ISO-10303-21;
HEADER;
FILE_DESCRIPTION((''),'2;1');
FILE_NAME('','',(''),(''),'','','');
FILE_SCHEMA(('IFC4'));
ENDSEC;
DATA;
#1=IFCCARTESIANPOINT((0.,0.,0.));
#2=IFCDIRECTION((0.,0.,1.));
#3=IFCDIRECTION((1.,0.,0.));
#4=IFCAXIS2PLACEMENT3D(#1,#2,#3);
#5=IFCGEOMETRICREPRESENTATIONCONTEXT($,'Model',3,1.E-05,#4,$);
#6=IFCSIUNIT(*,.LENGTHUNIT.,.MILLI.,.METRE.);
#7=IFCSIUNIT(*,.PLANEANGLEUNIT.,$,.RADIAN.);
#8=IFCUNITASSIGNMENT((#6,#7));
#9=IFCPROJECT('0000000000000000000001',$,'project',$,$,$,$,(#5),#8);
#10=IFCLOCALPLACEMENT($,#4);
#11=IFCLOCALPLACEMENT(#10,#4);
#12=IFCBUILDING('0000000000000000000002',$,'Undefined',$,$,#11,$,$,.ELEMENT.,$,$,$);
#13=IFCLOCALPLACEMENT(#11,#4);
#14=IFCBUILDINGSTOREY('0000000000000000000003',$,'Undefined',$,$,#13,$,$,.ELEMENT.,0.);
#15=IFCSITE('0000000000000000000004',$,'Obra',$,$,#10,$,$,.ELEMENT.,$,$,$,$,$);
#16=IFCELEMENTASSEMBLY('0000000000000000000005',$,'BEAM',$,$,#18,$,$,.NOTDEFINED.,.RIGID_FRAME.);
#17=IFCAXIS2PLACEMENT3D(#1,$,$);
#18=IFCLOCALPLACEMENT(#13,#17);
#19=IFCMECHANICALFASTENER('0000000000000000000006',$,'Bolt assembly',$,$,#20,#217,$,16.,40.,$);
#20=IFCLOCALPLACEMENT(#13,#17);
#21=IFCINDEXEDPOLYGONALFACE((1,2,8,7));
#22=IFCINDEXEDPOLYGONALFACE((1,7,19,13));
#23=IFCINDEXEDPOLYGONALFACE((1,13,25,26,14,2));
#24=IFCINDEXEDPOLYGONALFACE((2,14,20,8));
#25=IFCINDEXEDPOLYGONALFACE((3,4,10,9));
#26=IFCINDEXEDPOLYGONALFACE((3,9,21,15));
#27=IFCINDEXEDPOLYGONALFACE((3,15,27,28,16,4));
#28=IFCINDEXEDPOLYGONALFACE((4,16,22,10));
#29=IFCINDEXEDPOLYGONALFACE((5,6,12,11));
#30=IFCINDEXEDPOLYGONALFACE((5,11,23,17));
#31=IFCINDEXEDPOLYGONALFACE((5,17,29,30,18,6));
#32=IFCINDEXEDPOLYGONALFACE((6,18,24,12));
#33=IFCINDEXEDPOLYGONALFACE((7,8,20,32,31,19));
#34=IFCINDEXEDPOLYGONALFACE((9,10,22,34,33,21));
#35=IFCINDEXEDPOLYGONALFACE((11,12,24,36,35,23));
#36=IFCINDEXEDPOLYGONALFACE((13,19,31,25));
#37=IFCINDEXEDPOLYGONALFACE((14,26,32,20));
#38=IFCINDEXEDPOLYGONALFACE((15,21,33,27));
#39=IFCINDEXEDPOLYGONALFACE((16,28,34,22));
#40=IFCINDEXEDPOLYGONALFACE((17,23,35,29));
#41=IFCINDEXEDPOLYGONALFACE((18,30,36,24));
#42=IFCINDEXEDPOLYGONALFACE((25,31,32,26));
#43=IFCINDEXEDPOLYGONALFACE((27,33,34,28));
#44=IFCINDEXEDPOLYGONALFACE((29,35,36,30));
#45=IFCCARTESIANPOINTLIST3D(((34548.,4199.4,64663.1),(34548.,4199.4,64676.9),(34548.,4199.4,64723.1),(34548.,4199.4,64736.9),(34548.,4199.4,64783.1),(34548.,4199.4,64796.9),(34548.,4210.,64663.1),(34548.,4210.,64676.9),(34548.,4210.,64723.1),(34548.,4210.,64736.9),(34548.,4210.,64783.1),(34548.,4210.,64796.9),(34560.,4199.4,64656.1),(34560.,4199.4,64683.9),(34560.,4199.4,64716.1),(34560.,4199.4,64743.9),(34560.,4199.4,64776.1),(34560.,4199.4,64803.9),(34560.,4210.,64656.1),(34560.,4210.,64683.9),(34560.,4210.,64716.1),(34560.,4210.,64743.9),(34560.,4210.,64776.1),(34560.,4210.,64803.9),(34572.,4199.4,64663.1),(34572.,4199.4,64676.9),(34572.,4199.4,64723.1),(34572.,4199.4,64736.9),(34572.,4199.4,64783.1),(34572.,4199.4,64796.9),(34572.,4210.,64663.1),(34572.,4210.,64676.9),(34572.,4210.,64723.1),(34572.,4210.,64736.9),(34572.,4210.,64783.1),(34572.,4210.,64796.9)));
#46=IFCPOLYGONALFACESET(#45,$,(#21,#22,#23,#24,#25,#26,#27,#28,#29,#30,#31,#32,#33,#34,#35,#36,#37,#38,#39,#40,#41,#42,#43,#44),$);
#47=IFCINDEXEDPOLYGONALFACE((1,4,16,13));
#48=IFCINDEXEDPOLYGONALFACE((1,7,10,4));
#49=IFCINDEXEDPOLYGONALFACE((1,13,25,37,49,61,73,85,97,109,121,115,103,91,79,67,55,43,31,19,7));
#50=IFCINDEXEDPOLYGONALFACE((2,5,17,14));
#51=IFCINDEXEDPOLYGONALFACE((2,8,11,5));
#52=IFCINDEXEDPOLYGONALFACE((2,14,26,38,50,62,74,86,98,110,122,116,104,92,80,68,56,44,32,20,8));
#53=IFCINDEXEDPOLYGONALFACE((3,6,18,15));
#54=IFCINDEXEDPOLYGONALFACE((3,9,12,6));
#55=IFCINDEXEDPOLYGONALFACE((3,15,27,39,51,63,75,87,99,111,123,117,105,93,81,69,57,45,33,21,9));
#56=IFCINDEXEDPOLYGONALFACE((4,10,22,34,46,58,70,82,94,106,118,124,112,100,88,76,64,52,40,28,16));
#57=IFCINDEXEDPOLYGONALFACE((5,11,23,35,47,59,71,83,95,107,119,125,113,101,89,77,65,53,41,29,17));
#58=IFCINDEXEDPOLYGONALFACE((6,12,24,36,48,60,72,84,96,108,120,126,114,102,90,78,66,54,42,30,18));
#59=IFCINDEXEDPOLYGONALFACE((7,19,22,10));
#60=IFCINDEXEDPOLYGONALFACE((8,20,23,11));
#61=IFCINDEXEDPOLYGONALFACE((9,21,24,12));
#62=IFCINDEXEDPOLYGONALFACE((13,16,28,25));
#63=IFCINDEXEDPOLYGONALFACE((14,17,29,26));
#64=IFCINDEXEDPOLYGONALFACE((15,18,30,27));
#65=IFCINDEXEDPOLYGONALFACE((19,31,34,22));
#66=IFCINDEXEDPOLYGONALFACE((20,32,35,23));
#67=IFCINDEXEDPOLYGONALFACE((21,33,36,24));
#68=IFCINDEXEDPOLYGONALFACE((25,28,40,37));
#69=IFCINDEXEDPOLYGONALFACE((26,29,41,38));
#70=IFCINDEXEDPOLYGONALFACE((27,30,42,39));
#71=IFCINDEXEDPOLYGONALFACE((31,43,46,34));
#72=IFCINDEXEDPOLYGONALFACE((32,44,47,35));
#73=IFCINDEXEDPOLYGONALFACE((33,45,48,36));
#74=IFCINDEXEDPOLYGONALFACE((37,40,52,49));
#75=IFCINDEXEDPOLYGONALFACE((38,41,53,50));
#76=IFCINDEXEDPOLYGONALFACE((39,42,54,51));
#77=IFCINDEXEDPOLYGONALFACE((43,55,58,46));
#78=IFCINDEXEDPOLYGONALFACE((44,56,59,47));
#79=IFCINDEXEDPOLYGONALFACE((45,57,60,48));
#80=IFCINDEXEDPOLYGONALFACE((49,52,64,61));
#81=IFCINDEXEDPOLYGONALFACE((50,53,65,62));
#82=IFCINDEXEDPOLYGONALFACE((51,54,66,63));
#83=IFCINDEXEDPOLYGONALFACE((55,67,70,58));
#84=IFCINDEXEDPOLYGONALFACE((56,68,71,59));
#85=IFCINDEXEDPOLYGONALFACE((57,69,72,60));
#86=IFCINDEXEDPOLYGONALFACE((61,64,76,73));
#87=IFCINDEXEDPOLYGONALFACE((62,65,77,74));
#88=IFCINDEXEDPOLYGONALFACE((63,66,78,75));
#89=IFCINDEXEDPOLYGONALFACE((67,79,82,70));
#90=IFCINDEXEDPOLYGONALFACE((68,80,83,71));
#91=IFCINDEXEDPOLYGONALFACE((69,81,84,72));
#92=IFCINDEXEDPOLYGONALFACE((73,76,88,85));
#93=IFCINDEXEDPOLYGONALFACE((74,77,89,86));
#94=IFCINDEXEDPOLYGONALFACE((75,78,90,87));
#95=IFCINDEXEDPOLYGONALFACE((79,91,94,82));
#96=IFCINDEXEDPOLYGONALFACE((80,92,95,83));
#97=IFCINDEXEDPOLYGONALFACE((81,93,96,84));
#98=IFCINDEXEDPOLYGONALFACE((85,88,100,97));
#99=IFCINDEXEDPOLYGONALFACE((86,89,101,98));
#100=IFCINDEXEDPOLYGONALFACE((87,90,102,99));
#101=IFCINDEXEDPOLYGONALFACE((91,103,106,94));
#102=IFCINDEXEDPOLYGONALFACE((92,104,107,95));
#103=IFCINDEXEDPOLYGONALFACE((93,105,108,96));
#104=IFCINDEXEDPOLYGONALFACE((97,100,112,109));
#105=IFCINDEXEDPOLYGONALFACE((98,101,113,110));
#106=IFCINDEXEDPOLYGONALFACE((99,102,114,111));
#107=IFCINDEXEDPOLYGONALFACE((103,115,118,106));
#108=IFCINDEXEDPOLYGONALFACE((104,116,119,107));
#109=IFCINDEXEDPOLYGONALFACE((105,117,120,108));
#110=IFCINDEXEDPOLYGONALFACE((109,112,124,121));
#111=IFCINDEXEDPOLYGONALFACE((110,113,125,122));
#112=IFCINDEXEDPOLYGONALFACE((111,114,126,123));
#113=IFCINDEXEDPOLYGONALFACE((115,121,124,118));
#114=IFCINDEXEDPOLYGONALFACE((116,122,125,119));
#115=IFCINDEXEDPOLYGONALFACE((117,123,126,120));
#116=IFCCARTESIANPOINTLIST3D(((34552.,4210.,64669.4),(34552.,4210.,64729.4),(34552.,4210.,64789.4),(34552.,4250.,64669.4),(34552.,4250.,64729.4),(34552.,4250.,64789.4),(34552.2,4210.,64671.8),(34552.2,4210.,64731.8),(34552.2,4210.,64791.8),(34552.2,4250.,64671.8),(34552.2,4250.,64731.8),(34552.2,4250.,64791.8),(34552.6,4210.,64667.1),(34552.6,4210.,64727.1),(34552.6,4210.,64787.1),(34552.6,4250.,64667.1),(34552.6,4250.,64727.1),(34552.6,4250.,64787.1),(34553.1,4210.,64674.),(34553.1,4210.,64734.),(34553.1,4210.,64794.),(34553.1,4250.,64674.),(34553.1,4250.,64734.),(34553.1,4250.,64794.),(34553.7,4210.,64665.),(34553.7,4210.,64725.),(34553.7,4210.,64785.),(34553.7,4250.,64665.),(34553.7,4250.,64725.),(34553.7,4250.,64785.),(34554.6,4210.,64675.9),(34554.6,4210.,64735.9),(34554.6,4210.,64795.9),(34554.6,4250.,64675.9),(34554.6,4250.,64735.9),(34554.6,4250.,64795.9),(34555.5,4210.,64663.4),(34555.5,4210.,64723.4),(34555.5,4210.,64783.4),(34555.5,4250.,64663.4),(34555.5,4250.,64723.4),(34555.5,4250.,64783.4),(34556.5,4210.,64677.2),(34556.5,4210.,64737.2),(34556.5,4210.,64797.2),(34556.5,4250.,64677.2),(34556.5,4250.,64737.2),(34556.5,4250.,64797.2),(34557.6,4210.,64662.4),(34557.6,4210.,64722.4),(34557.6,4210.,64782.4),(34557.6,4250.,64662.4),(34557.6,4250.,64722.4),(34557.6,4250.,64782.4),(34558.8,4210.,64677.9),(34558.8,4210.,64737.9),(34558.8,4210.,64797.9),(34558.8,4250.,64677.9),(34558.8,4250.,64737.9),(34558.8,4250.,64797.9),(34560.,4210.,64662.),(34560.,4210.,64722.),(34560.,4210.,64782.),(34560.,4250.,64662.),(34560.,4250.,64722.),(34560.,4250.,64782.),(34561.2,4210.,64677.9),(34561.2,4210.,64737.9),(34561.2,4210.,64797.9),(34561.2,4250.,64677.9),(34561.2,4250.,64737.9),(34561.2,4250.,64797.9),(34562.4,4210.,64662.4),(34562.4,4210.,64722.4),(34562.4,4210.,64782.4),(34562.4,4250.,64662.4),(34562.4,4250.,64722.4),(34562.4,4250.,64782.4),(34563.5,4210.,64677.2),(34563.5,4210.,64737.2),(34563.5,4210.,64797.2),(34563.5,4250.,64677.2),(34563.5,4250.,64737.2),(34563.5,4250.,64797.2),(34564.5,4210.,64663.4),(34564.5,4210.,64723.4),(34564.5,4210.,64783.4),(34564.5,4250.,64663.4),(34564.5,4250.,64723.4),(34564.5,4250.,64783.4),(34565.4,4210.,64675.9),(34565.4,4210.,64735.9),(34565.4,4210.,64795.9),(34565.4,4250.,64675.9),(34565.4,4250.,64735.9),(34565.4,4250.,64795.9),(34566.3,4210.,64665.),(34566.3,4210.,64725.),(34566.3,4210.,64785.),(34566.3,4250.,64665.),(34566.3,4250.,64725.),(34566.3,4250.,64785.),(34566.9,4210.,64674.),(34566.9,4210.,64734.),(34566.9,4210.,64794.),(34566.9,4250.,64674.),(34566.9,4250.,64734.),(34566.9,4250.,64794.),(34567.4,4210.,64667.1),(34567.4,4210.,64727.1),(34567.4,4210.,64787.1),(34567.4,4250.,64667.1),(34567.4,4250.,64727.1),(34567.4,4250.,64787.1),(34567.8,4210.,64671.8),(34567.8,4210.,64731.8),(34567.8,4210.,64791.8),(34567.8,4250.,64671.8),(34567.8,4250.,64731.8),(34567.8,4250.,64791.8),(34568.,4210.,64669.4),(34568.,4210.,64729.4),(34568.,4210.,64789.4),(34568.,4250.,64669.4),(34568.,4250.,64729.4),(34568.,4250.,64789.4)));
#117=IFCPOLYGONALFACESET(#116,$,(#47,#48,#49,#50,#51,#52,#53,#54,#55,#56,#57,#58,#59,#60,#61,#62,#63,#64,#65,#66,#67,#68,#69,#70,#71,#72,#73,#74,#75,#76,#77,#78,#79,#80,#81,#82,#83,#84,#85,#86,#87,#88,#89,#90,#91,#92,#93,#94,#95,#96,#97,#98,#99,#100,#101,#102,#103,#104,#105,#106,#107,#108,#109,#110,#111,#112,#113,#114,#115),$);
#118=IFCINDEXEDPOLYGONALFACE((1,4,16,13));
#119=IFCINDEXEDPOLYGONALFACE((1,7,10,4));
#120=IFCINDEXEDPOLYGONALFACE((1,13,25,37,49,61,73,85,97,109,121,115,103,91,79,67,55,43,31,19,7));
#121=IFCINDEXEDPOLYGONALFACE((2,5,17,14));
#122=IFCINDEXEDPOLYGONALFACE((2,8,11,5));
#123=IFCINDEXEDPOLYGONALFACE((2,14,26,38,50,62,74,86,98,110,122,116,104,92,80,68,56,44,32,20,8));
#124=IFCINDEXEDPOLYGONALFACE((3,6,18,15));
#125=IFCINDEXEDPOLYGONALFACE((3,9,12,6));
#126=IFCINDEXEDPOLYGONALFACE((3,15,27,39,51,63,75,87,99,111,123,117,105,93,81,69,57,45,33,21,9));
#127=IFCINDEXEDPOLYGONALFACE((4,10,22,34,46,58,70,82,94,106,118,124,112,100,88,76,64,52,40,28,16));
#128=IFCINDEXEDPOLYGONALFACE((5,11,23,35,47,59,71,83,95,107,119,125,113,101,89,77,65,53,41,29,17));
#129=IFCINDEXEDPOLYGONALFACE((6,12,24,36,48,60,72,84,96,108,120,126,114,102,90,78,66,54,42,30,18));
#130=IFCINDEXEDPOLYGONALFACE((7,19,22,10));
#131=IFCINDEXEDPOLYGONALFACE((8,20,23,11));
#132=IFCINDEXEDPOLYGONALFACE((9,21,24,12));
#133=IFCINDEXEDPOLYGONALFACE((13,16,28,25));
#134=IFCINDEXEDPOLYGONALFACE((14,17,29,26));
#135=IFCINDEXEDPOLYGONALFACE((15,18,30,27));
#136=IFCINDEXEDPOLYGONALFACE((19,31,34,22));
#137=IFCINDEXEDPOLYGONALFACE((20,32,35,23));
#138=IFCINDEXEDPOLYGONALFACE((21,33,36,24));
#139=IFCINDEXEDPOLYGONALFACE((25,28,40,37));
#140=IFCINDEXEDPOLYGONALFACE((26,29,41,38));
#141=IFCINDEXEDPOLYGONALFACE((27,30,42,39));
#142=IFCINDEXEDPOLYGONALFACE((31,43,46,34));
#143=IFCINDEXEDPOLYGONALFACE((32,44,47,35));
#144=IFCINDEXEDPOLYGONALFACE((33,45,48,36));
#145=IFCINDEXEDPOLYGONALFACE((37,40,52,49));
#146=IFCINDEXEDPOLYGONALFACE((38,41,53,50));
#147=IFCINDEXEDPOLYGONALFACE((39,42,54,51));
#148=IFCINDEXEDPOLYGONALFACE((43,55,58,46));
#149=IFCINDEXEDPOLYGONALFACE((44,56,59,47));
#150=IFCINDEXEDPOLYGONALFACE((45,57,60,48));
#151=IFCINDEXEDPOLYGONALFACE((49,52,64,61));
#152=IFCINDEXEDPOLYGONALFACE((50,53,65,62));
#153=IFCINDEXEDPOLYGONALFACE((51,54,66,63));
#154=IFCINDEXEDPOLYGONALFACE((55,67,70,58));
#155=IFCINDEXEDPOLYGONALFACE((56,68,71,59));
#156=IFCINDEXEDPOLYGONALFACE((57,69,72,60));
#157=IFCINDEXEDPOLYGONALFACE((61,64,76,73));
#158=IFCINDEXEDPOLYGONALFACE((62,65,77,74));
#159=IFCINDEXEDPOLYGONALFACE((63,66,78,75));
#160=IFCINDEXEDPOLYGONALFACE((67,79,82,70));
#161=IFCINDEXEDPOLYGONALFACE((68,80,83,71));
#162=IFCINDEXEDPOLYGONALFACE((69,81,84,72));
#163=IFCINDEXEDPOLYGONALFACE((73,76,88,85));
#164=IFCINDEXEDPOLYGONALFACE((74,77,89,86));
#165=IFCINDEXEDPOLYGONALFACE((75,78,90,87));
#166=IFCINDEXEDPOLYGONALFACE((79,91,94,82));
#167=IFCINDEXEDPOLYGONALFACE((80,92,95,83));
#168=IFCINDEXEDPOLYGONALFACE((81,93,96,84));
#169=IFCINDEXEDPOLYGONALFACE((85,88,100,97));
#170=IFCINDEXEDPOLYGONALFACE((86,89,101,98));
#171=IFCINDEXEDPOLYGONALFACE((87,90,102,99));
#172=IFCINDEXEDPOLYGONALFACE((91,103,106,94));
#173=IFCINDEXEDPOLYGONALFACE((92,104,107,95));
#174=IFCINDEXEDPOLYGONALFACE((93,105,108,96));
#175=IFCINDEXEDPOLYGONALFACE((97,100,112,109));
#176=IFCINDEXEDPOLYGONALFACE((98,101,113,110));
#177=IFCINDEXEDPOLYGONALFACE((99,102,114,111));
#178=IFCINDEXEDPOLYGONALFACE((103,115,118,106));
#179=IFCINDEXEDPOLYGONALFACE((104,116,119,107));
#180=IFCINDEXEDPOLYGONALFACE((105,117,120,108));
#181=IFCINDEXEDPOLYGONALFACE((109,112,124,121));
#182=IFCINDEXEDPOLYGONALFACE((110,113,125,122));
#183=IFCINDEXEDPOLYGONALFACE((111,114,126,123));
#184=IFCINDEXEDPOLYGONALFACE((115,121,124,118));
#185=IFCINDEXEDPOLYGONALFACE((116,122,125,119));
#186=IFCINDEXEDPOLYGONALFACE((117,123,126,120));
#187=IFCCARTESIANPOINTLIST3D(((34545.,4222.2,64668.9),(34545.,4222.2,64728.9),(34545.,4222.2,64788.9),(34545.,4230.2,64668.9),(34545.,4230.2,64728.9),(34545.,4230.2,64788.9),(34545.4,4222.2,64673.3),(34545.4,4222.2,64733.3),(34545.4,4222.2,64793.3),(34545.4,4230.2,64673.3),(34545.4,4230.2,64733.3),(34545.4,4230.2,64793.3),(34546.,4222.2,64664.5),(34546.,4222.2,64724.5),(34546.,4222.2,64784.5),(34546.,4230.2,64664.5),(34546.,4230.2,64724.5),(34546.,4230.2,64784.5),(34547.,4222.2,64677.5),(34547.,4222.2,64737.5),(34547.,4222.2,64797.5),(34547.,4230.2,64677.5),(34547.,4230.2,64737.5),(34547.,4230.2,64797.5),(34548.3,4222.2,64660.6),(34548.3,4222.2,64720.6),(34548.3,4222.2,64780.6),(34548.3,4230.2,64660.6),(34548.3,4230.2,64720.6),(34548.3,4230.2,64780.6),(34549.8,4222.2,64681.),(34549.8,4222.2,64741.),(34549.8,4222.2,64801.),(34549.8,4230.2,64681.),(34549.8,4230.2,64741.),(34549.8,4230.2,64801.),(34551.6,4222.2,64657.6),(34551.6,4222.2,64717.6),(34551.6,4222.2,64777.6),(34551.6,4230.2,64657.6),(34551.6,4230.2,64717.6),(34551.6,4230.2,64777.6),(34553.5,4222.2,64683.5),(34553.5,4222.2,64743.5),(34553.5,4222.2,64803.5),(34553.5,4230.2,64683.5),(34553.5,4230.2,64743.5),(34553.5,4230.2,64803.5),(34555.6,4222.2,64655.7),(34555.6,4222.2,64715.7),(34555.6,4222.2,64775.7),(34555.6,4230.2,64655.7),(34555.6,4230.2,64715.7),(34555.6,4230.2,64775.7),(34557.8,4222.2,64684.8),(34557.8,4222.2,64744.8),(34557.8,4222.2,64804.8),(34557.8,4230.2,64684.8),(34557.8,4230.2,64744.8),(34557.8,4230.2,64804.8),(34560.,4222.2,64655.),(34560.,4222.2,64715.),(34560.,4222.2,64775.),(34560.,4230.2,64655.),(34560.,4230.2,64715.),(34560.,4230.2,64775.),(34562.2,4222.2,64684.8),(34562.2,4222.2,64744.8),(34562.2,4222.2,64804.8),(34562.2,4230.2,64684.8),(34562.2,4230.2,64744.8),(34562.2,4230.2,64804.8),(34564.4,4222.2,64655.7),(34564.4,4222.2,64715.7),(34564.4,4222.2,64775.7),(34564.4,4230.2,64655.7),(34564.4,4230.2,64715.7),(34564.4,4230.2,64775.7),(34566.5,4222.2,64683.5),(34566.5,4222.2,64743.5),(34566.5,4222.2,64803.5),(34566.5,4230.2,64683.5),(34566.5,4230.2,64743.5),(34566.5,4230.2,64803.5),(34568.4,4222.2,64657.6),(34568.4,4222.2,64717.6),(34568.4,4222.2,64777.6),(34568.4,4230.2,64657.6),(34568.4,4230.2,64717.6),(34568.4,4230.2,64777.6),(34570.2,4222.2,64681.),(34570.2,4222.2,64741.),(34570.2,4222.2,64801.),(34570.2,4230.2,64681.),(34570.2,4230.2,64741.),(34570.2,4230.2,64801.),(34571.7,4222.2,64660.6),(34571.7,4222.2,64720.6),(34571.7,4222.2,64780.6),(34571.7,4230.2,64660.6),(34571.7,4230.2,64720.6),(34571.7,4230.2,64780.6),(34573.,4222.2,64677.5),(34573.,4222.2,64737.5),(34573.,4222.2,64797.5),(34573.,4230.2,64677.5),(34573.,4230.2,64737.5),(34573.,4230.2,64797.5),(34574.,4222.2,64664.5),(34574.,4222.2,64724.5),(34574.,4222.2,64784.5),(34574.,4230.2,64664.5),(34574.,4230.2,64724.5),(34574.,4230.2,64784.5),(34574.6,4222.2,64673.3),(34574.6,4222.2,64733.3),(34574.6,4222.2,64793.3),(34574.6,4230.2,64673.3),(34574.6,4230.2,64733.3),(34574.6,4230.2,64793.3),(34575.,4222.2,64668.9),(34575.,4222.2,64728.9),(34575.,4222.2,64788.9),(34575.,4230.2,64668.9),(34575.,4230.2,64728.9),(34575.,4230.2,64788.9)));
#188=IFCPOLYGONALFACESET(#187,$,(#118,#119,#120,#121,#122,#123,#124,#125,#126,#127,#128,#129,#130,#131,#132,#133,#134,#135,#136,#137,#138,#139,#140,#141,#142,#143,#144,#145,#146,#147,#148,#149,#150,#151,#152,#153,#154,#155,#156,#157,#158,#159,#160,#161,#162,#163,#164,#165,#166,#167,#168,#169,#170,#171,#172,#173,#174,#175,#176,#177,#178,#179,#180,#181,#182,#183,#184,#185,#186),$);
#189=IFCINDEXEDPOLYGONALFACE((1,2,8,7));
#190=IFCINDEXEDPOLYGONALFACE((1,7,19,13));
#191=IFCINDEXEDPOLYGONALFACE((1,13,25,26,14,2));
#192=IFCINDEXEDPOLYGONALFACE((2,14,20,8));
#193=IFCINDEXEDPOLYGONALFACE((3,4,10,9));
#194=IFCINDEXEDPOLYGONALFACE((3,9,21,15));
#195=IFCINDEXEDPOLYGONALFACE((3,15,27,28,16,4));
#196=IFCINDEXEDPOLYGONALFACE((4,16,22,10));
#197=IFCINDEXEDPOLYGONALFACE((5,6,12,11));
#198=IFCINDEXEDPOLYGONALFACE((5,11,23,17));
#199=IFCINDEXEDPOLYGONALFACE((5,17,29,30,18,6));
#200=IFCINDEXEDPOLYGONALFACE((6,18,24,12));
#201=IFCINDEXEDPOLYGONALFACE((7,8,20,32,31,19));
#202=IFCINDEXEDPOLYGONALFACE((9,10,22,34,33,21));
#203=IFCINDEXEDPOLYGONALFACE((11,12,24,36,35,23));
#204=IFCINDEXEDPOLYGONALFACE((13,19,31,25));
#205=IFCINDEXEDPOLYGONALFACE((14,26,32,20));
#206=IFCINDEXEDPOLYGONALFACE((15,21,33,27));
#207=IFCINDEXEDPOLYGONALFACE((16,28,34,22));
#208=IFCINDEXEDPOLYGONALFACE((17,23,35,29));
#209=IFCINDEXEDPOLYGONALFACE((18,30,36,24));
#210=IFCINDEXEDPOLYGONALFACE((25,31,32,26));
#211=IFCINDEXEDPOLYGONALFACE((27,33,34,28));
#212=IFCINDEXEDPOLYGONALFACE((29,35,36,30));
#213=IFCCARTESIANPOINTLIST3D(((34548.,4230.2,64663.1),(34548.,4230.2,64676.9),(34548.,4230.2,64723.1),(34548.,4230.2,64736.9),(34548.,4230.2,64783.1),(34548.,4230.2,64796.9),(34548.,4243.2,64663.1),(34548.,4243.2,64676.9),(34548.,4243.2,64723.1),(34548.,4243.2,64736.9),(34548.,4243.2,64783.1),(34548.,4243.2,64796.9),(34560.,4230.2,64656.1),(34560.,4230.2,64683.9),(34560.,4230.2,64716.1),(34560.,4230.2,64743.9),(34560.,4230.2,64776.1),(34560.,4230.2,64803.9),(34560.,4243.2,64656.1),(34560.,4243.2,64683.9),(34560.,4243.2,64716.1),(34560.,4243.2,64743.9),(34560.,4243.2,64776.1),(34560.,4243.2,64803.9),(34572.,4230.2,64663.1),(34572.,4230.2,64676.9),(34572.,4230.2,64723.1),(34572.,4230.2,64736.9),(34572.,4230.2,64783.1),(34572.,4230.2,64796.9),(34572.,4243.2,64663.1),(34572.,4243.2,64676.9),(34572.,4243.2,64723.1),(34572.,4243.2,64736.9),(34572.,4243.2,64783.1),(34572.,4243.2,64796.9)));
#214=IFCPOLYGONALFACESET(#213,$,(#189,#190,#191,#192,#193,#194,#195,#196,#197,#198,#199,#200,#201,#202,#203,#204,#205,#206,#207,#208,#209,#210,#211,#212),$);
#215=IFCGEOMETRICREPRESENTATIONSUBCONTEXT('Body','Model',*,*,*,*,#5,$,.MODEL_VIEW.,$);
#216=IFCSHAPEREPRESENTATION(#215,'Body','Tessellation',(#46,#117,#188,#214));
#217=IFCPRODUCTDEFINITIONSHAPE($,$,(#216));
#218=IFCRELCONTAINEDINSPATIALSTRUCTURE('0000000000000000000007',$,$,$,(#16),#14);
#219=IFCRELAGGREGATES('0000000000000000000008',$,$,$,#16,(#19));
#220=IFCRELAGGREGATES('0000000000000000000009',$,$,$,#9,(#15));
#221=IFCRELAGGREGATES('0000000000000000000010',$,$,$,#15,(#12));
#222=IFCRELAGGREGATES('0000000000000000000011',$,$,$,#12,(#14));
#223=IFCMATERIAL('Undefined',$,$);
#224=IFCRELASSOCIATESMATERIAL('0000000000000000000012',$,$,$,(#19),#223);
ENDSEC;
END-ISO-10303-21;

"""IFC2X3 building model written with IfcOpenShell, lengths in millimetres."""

from ifc_helpers import new_model, si_unit, frame, origin_with_axes, origin_2d_with_axis, place, context, subcontext, project, spatial, polyline, circle, outline, extrude, source, transform, mapped, material, element, aggregate, save


model = new_model("IFC2X3")

# Units and contexts
model_context = context("Model", 3, precision=1e-05, world=origin_with_axes())
body_context = subcontext(model_context, "Body", "Model", "MODEL_VIEW")
ifc_project = project(units=[si_unit("LENGTHUNIT", "METRE", prefix="MILLI"), si_unit("PLANEANGLEUNIT", "RADIAN")], contexts=[model_context])

# Site, building, storey
site_placement = place(None, origin_with_axes())
site = spatial("IfcSite", under=ifc_project, at=site_placement, Name="Obra", CompositionType="ELEMENT")
building_placement = place(site_placement, origin_with_axes())
building = spatial("IfcBuilding", under=site, at=building_placement, Name="Undefined", CompositionType="ELEMENT")
storey_placement = place(building_placement, origin_with_axes())
storey = spatial("IfcBuildingStorey", under=building, at=storey_placement, Name="Undefined", CompositionType="ELEMENT", Elevation=0.0)

# Shared definitions
ifc_material = material(Name="Undefined")

# Element assembly
assembly_1_placement = place(storey_placement, origin_with_axes())
assembly_1 = element("IfcElementAssembly", 1, at=assembly_1_placement, inside=storey, Name="BEAM", AssemblyPlace="NOTDEFINED", PredefinedType="RIGID_FRAME")

# Mechanical fastener
shared_shape_1 = source(origin_with_axes(), body_context, "Body", "SweptSolid", [
    extrude(outline(polyline([(13.9, 0.0), (6.9, 12.0), (-6.9, 12.0), (-13.9, 0.0), (-6.9, -12.0), (6.9, -12.0), (13.9, 0.0)])), frame((0.0, -19.7, 0.0), z_axis=(0.0, 1.0, 0.0), x_axis=(1.0, 0.0, 0.0)), (0.0, 0.0, 1.0), 10.6),
    extrude(circle(Radius=8.0, at=origin_2d_with_axis()), frame((0.0, -9.1, 0.0), z_axis=(0.0, 1.0, 0.0), x_axis=(1.0, 0.0, 0.0)), (0.0, 0.0, 1.0), 40.0),
    extrude(circle(Radius=15.0, at=origin_2d_with_axis()), frame((0.0, 3.1, 0.0), z_axis=(0.0, 1.0, 0.0), x_axis=(1.0, 0.0, 0.0)), (0.0, 0.0, 1.0), 8.0),
    extrude(outline(polyline([(13.9, 0.0), (6.9, 12.0), (-6.9, 12.0), (-13.9, 0.0), (-6.9, -12.0), (6.9, -12.0), (13.9, 0.0)])), frame((0.0, 11.1, 0.0), z_axis=(0.0, 1.0, 0.0), x_axis=(1.0, 0.0, 0.0)), (0.0, 0.0, 1.0), 13.0),
])
mechanical_fastener_1_placement = place(assembly_1_placement, frame((34510.0, 4219.1, 64850.0), z_axis=(1.0, 0.0, 0.0), x_axis=(0.0, 0.0, -1.0)))
mechanical_fastener_1 = element("IfcMechanicalFastener", 2, at=mechanical_fastener_1_placement, material=ifc_material, Name="Bolt assembly", NominalDiameter=16.0, NominalLength=40.0, context=body_context, shape_type="MappedRepresentation", body=[
    mapped(shared_shape_1, transform((60.0, 0.0, 50.0))),
    mapped(shared_shape_1, transform((120.0, 0.0, 50.0))),
    mapped(shared_shape_1, transform((180.0, 0.0, 50.0))),
])
aggregate(assembly_1, [mechanical_fastener_1])

save(model, "model.ifc")
